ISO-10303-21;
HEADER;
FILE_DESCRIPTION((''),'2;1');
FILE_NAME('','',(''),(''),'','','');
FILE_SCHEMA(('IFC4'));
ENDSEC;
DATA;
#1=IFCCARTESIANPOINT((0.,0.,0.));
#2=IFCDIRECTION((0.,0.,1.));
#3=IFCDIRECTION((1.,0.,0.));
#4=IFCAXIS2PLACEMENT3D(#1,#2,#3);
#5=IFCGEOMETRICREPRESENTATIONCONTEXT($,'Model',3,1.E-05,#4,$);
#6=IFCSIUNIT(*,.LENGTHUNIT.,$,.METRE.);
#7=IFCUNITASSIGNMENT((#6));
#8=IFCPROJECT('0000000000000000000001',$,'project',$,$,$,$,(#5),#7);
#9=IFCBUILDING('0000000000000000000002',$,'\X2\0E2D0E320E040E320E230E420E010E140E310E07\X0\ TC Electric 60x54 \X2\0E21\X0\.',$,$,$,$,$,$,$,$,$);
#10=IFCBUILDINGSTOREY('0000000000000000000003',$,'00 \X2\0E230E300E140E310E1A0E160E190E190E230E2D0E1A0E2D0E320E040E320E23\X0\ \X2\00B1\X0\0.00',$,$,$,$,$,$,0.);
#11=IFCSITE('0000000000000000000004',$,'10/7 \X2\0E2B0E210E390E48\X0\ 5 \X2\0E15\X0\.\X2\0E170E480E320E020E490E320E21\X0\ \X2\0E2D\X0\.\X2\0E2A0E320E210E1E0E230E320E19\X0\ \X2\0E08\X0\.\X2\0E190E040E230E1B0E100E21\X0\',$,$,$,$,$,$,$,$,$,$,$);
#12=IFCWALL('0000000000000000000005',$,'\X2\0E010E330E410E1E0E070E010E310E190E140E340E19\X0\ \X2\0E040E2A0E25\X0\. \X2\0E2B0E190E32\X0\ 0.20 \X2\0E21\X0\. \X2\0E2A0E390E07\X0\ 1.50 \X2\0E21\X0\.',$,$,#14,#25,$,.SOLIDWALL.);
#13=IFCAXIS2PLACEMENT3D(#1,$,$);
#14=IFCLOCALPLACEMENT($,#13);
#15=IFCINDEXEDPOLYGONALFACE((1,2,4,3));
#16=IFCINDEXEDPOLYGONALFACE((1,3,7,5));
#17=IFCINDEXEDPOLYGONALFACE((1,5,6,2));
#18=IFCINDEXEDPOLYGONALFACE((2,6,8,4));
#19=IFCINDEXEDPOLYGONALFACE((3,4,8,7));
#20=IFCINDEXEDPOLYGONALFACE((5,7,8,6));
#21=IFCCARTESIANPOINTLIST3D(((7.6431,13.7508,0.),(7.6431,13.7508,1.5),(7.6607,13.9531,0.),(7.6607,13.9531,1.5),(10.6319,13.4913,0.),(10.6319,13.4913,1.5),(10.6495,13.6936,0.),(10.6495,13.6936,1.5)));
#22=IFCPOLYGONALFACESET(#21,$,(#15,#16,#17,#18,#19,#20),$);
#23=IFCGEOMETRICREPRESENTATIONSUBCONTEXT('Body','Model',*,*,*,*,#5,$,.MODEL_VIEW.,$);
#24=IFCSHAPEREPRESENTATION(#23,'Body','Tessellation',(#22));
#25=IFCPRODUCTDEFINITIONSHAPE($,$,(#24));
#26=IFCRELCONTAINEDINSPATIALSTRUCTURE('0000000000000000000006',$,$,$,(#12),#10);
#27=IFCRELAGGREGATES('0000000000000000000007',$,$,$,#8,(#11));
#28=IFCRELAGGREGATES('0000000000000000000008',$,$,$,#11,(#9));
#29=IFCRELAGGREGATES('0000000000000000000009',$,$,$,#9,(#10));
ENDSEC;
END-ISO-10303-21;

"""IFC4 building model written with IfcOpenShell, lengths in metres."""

from ifc_helpers import new_model, si_unit, frame, origin, origin_with_axes, origin_2d, place, context, subcontext, project, spatial, rectangle, extrude, element, save


model = new_model("IFC4")

# Units and contexts
model_context = context("Model", 3, precision=1e-05, world=origin_with_axes())
body_context = subcontext(model_context, "Body", "Model", "MODEL_VIEW")
ifc_project = project(units=[si_unit("LENGTHUNIT", "METRE")], contexts=[model_context])

# Site, building, storey
site = spatial("IfcSite", under=ifc_project, Name="10/7 หมู่ 5 ต.ท่าข้าม อ.สามพราน จ.นครปฐม")
building = spatial("IfcBuilding", under=site, Name="อาคารโกดัง TC Electric 60x54 ม.")
storey = spatial("IfcBuildingStorey", under=building, Name="00 ระดับถนนรอบอาคาร ±0.00", Elevation=0.0)

# Wall
for number, where, z_axis, x_axis, name in (
    (1, (9.1463, 13.7222, 0.0), (0.0, 0.0, 1.0), (0.9962, -0.0865, 0.0), "กำแพงกันดิน คสล. หนา 0.20 ม. สูง 1.50 ม."),
):
    element("IfcWall", number, at=place(None, frame(where, z_axis=z_axis, x_axis=x_axis)), inside=storey, Name=name, PredefinedType="SOLIDWALL", context=body_context, shape_type="SweptSolid", body=[
        extrude(rectangle(XDim=3.0, YDim=0.203, at=origin_2d()), origin(), (0.0, 0.0, 1.0), 1.5),
    ])

save(model, "model.ifc")
